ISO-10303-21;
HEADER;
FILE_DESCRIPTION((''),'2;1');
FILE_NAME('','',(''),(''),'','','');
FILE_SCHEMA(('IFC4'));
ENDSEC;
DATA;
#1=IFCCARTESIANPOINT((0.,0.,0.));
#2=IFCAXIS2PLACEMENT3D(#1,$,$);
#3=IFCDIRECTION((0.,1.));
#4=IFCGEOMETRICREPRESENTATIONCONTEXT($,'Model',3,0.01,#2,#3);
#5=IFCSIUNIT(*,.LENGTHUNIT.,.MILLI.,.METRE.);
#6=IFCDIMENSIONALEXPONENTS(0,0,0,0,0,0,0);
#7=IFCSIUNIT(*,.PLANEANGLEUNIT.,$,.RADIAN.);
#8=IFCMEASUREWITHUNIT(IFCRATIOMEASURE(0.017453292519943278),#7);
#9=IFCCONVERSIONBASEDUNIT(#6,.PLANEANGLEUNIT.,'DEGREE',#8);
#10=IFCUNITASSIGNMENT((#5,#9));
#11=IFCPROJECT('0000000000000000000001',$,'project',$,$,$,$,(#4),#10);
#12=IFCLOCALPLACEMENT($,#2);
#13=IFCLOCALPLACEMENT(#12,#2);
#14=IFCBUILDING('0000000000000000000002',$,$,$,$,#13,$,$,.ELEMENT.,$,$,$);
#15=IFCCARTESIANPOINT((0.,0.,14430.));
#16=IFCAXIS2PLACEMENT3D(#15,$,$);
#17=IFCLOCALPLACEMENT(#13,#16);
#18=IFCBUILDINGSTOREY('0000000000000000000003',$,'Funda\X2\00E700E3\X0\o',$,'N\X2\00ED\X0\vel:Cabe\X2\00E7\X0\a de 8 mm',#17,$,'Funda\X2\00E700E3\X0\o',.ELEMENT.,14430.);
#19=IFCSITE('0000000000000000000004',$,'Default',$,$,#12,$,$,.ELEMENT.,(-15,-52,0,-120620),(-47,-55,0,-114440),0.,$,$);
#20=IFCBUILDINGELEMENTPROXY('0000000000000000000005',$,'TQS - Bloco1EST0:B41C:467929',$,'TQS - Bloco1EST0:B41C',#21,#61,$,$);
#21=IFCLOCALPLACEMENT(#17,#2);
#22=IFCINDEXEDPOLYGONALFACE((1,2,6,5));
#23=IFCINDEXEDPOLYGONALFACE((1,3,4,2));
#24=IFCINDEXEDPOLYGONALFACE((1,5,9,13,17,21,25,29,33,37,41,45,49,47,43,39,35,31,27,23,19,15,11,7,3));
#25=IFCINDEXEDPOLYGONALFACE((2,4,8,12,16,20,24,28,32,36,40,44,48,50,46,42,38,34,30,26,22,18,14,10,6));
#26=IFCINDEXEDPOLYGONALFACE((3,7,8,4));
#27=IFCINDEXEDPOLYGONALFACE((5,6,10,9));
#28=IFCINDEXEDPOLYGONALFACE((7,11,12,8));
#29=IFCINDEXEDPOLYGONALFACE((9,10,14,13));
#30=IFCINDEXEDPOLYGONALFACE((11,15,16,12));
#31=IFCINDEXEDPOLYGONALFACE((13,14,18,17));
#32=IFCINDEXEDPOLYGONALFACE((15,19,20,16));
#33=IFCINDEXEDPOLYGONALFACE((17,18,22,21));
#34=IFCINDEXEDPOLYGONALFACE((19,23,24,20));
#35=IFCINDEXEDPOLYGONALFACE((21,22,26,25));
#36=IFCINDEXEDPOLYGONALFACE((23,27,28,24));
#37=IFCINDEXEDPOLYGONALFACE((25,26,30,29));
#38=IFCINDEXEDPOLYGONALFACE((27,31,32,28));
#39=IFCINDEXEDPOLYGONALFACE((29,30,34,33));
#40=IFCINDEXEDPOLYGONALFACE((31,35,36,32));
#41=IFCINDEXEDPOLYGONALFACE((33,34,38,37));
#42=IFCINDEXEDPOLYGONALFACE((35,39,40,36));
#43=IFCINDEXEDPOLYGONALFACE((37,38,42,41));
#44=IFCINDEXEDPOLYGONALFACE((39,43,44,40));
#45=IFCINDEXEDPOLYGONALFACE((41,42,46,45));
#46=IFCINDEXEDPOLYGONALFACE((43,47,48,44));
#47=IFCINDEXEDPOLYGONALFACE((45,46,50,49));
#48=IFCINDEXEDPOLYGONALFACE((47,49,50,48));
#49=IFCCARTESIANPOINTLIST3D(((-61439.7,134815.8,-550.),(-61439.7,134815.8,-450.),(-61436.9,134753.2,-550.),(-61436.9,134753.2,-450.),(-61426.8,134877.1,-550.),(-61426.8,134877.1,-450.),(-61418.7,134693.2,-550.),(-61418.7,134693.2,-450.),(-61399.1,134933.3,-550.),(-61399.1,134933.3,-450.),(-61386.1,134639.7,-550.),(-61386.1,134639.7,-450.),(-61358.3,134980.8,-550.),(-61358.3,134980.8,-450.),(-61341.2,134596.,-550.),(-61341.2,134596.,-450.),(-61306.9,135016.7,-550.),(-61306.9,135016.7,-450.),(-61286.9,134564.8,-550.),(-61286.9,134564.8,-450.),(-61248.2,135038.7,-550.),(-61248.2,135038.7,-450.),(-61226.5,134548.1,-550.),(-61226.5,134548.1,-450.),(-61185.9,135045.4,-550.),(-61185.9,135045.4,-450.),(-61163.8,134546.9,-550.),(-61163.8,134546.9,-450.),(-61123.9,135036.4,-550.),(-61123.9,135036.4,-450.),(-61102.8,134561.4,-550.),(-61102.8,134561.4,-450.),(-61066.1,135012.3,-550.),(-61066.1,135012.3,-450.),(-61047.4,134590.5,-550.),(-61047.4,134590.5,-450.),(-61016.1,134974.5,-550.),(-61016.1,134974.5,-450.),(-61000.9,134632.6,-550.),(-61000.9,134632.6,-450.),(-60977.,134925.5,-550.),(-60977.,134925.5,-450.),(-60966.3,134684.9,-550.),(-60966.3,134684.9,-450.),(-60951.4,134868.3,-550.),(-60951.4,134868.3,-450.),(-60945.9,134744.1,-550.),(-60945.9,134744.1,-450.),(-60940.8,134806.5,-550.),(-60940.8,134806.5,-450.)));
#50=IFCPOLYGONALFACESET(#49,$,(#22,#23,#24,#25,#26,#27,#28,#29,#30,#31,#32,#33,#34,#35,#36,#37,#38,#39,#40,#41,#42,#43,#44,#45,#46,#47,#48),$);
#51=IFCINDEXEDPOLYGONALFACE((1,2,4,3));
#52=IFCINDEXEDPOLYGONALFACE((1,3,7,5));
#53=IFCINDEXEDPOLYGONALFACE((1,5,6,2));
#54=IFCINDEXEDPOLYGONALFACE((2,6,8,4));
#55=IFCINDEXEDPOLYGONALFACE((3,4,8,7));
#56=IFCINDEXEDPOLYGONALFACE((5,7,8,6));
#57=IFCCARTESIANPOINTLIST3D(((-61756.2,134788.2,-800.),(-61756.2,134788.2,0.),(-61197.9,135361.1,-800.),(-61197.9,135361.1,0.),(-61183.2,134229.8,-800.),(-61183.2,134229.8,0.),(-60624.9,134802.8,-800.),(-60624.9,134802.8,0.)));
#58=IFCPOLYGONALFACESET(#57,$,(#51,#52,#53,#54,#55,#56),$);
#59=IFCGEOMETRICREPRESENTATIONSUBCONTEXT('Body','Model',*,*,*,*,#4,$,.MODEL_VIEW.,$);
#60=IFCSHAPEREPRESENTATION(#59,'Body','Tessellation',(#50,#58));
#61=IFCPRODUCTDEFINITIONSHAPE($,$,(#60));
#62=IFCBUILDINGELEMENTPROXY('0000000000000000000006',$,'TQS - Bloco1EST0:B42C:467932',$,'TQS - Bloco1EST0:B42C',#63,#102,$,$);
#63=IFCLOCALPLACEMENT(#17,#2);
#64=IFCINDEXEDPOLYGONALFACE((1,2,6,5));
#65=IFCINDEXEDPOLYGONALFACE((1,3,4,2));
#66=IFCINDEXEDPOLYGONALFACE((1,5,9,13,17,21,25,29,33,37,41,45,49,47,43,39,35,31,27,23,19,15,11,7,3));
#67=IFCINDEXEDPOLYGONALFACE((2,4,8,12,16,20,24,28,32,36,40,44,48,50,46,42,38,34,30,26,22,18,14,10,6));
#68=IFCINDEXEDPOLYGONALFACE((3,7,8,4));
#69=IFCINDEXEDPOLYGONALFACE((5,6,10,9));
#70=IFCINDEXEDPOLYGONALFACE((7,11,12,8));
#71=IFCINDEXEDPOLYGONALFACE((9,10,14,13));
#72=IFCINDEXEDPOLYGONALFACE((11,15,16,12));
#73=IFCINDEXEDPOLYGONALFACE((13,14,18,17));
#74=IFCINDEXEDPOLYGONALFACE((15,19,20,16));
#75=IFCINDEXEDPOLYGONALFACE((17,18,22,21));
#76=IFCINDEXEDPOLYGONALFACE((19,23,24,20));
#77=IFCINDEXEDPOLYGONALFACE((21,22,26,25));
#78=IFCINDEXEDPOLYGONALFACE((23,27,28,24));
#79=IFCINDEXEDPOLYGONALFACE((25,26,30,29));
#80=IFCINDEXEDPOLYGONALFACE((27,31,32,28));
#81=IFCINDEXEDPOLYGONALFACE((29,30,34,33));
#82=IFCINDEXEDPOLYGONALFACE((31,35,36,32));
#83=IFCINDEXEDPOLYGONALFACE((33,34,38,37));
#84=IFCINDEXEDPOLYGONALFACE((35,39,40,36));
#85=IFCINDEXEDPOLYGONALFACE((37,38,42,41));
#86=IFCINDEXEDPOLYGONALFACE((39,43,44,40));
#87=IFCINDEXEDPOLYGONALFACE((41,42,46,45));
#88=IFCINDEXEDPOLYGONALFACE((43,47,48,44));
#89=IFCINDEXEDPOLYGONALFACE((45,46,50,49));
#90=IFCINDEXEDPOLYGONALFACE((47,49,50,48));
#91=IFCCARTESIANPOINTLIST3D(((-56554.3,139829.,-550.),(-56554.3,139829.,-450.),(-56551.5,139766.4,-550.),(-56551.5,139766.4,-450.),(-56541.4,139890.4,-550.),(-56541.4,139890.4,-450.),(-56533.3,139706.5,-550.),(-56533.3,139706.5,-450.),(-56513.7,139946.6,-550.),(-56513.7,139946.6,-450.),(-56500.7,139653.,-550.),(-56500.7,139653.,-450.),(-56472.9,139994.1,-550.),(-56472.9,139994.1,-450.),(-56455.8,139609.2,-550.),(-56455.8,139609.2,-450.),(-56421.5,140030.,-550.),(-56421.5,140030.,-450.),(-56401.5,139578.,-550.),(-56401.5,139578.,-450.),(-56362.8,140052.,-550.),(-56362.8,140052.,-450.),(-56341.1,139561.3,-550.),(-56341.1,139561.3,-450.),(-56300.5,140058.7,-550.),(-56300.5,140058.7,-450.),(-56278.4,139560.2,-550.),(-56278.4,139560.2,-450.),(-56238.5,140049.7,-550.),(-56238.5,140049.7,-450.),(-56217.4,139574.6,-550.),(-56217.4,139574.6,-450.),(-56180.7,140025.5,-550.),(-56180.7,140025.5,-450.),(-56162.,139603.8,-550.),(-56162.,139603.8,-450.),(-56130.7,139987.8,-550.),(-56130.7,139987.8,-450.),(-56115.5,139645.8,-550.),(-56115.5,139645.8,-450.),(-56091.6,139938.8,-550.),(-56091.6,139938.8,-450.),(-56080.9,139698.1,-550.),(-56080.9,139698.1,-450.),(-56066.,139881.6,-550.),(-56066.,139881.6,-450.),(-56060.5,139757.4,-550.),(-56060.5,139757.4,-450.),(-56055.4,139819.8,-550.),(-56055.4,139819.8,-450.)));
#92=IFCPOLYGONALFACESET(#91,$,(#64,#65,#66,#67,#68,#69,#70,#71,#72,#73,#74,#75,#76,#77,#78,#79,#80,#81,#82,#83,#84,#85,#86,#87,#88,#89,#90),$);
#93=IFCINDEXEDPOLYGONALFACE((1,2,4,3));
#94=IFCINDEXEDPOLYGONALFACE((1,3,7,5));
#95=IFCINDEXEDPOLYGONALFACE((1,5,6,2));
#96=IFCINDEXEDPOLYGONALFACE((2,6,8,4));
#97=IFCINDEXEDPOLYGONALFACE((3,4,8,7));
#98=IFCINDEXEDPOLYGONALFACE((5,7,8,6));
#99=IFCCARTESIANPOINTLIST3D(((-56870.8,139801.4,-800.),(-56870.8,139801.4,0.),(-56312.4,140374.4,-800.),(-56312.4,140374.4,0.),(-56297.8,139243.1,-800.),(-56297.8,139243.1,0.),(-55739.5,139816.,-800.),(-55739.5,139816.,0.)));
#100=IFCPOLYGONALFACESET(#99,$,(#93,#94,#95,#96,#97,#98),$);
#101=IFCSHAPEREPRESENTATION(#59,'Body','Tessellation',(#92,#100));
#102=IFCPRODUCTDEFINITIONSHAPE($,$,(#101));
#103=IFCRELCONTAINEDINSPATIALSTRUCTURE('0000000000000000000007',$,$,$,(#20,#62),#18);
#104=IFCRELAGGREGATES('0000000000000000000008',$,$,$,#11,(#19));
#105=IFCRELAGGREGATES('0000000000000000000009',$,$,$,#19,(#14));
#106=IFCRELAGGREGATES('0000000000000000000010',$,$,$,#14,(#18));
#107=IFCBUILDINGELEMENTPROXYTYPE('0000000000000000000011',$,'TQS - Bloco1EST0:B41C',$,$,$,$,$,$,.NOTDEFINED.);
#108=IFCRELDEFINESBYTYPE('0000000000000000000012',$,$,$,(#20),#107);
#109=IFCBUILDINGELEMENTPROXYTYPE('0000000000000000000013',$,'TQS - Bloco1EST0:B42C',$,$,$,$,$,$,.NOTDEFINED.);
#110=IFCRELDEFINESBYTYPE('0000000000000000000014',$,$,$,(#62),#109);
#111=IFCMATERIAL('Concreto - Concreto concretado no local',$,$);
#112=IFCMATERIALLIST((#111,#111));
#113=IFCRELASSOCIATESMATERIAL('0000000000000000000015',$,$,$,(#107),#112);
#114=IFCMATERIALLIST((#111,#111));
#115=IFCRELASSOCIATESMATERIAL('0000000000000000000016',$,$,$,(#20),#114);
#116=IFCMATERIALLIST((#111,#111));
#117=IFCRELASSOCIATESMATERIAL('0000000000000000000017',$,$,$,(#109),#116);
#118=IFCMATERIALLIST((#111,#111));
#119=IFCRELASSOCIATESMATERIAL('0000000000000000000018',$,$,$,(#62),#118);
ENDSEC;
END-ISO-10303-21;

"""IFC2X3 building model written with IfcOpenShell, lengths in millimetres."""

from ifc_helpers import new_model, entity, si_unit, converted_unit, direction, frame, frame_2d, origin, origin_2d_with_axis, place, context, subcontext, project, spatial, rectangle, circle, extrude, source, transform, mapped, material, material_list, type_object, type_shapes, element, save


model = new_model("IFC2X3")

# Units and contexts
model_context = context("Model", 3, precision=0.01, world=origin(), true_north=direction((0.0, 1.0)))
body_context = subcontext(model_context, "Body", "Model", "MODEL_VIEW")
ifc_project = project(units=[si_unit("LENGTHUNIT", "METRE", prefix="MILLI"), converted_unit("PLANEANGLEUNIT", "DEGREE", entity("IfcRatioMeasure", 0.017453292519943278), si_unit("PLANEANGLEUNIT", "RADIAN"), dimensions=[0, 0, 0, 0, 0, 0, 0])], contexts=[model_context])

# Site, building, storey
site_placement = place(None, origin())
site = spatial("IfcSite", under=ifc_project, at=site_placement, Name="Default", CompositionType="ELEMENT", RefLatitude=(-15, -52, 0, -120620), RefLongitude=(-47, -55, 0, -114440), RefElevation=0.0)
building_placement = place(site_placement, origin())
building = spatial("IfcBuilding", under=site, at=building_placement, CompositionType="ELEMENT")
storey_placement = place(building_placement, frame((0.0, 0.0, 14430.0)))
storey = spatial("IfcBuildingStorey", under=building, at=storey_placement, Name="Fundação", ObjectType="Nível:Cabeça de 8 mm", LongName="Fundação", CompositionType="ELEMENT", Elevation=14430.0)

# Building element proxies
ifc_material_1 = material(Name="Concreto - Concreto concretado no local")
ifc_material_list_1 = material_list([ifc_material_1, ifc_material_1])
ifc_material_list_2 = material_list([ifc_material_1, ifc_material_1])
building_element_proxy_type_1 = type_object("IfcBuildingElementProxyType", Name="TQS - Bloco1EST0:B41C", PredefinedType="NOTDEFINED", material=ifc_material_list_2)
shared_shape_1 = source(origin(), body_context, "Body", "SweptSolid", [
    extrude(circle(Radius=250.0, at=frame_2d((0.0, 0.0), x_axis=(1.0, 0.0))), frame((0.0, 0.0, -550.0)), (0.0, 0.0, 1.0), 100.0),
    extrude(rectangle(XDim=800.0, YDim=800.0, at=origin_2d_with_axis()), frame((0.0, 0.0, -800.0), z_axis=(0.0, 0.0, 1.0), x_axis=(-1.0, 0.0, 0.0)), (0.0, 0.0, 1.0), 800.0),
])
type_shapes(building_element_proxy_type_1, [shared_shape_1])
proxy_1_placement = place(storey_placement, frame((-61190.5, 134795.5, 0.0), z_axis=(0.0, 0.0, 1.0), x_axis=(0.697915, 0.71618, 0.0)))
element("IfcBuildingElementProxy", 1, at=proxy_1_placement, inside=storey, type_object=building_element_proxy_type_1, material=ifc_material_list_1, Name="TQS - Bloco1EST0:B41C:467929", ObjectType="TQS - Bloco1EST0:B41C", context=body_context, shape_type="MappedRepresentation", body=[
    mapped(shared_shape_1, transform((0.0, 0.0, 0.0), scale=1.0)),
])
ifc_material_list_3 = material_list([ifc_material_1, ifc_material_1])
ifc_material_list_4 = material_list([ifc_material_1, ifc_material_1])
building_element_proxy_type_2 = type_object("IfcBuildingElementProxyType", Name="TQS - Bloco1EST0:B42C", PredefinedType="NOTDEFINED", material=ifc_material_list_4)
shared_shape_2 = source(origin(), body_context, "Body", "SweptSolid", [
    extrude(circle(Radius=250.0, at=frame_2d((0.0, 0.0), x_axis=(1.0, 0.0))), frame((0.0, 0.0, -550.0)), (0.0, 0.0, 1.0), 100.0),
    extrude(rectangle(XDim=800.0, YDim=800.0, at=origin_2d_with_axis()), frame((0.0, 0.0, -800.0), z_axis=(0.0, 0.0, 1.0), x_axis=(-1.0, 0.0, 0.0)), (0.0, 0.0, 1.0), 800.0),
])
type_shapes(building_element_proxy_type_2, [shared_shape_2])
proxy_2_placement = place(storey_placement, frame((-56305.1, 139808.7, 0.0), z_axis=(0.0, 0.0, 1.0), x_axis=(0.697915, 0.71618, 0.0)))
element("IfcBuildingElementProxy", 2, at=proxy_2_placement, inside=storey, type_object=building_element_proxy_type_2, material=ifc_material_list_3, Name="TQS - Bloco1EST0:B42C:467932", ObjectType="TQS - Bloco1EST0:B42C", context=body_context, shape_type="MappedRepresentation", body=[
    mapped(shared_shape_2, transform((0.0, 0.0, 0.0), scale=1.0)),
])

save(model, "model.ifc")
